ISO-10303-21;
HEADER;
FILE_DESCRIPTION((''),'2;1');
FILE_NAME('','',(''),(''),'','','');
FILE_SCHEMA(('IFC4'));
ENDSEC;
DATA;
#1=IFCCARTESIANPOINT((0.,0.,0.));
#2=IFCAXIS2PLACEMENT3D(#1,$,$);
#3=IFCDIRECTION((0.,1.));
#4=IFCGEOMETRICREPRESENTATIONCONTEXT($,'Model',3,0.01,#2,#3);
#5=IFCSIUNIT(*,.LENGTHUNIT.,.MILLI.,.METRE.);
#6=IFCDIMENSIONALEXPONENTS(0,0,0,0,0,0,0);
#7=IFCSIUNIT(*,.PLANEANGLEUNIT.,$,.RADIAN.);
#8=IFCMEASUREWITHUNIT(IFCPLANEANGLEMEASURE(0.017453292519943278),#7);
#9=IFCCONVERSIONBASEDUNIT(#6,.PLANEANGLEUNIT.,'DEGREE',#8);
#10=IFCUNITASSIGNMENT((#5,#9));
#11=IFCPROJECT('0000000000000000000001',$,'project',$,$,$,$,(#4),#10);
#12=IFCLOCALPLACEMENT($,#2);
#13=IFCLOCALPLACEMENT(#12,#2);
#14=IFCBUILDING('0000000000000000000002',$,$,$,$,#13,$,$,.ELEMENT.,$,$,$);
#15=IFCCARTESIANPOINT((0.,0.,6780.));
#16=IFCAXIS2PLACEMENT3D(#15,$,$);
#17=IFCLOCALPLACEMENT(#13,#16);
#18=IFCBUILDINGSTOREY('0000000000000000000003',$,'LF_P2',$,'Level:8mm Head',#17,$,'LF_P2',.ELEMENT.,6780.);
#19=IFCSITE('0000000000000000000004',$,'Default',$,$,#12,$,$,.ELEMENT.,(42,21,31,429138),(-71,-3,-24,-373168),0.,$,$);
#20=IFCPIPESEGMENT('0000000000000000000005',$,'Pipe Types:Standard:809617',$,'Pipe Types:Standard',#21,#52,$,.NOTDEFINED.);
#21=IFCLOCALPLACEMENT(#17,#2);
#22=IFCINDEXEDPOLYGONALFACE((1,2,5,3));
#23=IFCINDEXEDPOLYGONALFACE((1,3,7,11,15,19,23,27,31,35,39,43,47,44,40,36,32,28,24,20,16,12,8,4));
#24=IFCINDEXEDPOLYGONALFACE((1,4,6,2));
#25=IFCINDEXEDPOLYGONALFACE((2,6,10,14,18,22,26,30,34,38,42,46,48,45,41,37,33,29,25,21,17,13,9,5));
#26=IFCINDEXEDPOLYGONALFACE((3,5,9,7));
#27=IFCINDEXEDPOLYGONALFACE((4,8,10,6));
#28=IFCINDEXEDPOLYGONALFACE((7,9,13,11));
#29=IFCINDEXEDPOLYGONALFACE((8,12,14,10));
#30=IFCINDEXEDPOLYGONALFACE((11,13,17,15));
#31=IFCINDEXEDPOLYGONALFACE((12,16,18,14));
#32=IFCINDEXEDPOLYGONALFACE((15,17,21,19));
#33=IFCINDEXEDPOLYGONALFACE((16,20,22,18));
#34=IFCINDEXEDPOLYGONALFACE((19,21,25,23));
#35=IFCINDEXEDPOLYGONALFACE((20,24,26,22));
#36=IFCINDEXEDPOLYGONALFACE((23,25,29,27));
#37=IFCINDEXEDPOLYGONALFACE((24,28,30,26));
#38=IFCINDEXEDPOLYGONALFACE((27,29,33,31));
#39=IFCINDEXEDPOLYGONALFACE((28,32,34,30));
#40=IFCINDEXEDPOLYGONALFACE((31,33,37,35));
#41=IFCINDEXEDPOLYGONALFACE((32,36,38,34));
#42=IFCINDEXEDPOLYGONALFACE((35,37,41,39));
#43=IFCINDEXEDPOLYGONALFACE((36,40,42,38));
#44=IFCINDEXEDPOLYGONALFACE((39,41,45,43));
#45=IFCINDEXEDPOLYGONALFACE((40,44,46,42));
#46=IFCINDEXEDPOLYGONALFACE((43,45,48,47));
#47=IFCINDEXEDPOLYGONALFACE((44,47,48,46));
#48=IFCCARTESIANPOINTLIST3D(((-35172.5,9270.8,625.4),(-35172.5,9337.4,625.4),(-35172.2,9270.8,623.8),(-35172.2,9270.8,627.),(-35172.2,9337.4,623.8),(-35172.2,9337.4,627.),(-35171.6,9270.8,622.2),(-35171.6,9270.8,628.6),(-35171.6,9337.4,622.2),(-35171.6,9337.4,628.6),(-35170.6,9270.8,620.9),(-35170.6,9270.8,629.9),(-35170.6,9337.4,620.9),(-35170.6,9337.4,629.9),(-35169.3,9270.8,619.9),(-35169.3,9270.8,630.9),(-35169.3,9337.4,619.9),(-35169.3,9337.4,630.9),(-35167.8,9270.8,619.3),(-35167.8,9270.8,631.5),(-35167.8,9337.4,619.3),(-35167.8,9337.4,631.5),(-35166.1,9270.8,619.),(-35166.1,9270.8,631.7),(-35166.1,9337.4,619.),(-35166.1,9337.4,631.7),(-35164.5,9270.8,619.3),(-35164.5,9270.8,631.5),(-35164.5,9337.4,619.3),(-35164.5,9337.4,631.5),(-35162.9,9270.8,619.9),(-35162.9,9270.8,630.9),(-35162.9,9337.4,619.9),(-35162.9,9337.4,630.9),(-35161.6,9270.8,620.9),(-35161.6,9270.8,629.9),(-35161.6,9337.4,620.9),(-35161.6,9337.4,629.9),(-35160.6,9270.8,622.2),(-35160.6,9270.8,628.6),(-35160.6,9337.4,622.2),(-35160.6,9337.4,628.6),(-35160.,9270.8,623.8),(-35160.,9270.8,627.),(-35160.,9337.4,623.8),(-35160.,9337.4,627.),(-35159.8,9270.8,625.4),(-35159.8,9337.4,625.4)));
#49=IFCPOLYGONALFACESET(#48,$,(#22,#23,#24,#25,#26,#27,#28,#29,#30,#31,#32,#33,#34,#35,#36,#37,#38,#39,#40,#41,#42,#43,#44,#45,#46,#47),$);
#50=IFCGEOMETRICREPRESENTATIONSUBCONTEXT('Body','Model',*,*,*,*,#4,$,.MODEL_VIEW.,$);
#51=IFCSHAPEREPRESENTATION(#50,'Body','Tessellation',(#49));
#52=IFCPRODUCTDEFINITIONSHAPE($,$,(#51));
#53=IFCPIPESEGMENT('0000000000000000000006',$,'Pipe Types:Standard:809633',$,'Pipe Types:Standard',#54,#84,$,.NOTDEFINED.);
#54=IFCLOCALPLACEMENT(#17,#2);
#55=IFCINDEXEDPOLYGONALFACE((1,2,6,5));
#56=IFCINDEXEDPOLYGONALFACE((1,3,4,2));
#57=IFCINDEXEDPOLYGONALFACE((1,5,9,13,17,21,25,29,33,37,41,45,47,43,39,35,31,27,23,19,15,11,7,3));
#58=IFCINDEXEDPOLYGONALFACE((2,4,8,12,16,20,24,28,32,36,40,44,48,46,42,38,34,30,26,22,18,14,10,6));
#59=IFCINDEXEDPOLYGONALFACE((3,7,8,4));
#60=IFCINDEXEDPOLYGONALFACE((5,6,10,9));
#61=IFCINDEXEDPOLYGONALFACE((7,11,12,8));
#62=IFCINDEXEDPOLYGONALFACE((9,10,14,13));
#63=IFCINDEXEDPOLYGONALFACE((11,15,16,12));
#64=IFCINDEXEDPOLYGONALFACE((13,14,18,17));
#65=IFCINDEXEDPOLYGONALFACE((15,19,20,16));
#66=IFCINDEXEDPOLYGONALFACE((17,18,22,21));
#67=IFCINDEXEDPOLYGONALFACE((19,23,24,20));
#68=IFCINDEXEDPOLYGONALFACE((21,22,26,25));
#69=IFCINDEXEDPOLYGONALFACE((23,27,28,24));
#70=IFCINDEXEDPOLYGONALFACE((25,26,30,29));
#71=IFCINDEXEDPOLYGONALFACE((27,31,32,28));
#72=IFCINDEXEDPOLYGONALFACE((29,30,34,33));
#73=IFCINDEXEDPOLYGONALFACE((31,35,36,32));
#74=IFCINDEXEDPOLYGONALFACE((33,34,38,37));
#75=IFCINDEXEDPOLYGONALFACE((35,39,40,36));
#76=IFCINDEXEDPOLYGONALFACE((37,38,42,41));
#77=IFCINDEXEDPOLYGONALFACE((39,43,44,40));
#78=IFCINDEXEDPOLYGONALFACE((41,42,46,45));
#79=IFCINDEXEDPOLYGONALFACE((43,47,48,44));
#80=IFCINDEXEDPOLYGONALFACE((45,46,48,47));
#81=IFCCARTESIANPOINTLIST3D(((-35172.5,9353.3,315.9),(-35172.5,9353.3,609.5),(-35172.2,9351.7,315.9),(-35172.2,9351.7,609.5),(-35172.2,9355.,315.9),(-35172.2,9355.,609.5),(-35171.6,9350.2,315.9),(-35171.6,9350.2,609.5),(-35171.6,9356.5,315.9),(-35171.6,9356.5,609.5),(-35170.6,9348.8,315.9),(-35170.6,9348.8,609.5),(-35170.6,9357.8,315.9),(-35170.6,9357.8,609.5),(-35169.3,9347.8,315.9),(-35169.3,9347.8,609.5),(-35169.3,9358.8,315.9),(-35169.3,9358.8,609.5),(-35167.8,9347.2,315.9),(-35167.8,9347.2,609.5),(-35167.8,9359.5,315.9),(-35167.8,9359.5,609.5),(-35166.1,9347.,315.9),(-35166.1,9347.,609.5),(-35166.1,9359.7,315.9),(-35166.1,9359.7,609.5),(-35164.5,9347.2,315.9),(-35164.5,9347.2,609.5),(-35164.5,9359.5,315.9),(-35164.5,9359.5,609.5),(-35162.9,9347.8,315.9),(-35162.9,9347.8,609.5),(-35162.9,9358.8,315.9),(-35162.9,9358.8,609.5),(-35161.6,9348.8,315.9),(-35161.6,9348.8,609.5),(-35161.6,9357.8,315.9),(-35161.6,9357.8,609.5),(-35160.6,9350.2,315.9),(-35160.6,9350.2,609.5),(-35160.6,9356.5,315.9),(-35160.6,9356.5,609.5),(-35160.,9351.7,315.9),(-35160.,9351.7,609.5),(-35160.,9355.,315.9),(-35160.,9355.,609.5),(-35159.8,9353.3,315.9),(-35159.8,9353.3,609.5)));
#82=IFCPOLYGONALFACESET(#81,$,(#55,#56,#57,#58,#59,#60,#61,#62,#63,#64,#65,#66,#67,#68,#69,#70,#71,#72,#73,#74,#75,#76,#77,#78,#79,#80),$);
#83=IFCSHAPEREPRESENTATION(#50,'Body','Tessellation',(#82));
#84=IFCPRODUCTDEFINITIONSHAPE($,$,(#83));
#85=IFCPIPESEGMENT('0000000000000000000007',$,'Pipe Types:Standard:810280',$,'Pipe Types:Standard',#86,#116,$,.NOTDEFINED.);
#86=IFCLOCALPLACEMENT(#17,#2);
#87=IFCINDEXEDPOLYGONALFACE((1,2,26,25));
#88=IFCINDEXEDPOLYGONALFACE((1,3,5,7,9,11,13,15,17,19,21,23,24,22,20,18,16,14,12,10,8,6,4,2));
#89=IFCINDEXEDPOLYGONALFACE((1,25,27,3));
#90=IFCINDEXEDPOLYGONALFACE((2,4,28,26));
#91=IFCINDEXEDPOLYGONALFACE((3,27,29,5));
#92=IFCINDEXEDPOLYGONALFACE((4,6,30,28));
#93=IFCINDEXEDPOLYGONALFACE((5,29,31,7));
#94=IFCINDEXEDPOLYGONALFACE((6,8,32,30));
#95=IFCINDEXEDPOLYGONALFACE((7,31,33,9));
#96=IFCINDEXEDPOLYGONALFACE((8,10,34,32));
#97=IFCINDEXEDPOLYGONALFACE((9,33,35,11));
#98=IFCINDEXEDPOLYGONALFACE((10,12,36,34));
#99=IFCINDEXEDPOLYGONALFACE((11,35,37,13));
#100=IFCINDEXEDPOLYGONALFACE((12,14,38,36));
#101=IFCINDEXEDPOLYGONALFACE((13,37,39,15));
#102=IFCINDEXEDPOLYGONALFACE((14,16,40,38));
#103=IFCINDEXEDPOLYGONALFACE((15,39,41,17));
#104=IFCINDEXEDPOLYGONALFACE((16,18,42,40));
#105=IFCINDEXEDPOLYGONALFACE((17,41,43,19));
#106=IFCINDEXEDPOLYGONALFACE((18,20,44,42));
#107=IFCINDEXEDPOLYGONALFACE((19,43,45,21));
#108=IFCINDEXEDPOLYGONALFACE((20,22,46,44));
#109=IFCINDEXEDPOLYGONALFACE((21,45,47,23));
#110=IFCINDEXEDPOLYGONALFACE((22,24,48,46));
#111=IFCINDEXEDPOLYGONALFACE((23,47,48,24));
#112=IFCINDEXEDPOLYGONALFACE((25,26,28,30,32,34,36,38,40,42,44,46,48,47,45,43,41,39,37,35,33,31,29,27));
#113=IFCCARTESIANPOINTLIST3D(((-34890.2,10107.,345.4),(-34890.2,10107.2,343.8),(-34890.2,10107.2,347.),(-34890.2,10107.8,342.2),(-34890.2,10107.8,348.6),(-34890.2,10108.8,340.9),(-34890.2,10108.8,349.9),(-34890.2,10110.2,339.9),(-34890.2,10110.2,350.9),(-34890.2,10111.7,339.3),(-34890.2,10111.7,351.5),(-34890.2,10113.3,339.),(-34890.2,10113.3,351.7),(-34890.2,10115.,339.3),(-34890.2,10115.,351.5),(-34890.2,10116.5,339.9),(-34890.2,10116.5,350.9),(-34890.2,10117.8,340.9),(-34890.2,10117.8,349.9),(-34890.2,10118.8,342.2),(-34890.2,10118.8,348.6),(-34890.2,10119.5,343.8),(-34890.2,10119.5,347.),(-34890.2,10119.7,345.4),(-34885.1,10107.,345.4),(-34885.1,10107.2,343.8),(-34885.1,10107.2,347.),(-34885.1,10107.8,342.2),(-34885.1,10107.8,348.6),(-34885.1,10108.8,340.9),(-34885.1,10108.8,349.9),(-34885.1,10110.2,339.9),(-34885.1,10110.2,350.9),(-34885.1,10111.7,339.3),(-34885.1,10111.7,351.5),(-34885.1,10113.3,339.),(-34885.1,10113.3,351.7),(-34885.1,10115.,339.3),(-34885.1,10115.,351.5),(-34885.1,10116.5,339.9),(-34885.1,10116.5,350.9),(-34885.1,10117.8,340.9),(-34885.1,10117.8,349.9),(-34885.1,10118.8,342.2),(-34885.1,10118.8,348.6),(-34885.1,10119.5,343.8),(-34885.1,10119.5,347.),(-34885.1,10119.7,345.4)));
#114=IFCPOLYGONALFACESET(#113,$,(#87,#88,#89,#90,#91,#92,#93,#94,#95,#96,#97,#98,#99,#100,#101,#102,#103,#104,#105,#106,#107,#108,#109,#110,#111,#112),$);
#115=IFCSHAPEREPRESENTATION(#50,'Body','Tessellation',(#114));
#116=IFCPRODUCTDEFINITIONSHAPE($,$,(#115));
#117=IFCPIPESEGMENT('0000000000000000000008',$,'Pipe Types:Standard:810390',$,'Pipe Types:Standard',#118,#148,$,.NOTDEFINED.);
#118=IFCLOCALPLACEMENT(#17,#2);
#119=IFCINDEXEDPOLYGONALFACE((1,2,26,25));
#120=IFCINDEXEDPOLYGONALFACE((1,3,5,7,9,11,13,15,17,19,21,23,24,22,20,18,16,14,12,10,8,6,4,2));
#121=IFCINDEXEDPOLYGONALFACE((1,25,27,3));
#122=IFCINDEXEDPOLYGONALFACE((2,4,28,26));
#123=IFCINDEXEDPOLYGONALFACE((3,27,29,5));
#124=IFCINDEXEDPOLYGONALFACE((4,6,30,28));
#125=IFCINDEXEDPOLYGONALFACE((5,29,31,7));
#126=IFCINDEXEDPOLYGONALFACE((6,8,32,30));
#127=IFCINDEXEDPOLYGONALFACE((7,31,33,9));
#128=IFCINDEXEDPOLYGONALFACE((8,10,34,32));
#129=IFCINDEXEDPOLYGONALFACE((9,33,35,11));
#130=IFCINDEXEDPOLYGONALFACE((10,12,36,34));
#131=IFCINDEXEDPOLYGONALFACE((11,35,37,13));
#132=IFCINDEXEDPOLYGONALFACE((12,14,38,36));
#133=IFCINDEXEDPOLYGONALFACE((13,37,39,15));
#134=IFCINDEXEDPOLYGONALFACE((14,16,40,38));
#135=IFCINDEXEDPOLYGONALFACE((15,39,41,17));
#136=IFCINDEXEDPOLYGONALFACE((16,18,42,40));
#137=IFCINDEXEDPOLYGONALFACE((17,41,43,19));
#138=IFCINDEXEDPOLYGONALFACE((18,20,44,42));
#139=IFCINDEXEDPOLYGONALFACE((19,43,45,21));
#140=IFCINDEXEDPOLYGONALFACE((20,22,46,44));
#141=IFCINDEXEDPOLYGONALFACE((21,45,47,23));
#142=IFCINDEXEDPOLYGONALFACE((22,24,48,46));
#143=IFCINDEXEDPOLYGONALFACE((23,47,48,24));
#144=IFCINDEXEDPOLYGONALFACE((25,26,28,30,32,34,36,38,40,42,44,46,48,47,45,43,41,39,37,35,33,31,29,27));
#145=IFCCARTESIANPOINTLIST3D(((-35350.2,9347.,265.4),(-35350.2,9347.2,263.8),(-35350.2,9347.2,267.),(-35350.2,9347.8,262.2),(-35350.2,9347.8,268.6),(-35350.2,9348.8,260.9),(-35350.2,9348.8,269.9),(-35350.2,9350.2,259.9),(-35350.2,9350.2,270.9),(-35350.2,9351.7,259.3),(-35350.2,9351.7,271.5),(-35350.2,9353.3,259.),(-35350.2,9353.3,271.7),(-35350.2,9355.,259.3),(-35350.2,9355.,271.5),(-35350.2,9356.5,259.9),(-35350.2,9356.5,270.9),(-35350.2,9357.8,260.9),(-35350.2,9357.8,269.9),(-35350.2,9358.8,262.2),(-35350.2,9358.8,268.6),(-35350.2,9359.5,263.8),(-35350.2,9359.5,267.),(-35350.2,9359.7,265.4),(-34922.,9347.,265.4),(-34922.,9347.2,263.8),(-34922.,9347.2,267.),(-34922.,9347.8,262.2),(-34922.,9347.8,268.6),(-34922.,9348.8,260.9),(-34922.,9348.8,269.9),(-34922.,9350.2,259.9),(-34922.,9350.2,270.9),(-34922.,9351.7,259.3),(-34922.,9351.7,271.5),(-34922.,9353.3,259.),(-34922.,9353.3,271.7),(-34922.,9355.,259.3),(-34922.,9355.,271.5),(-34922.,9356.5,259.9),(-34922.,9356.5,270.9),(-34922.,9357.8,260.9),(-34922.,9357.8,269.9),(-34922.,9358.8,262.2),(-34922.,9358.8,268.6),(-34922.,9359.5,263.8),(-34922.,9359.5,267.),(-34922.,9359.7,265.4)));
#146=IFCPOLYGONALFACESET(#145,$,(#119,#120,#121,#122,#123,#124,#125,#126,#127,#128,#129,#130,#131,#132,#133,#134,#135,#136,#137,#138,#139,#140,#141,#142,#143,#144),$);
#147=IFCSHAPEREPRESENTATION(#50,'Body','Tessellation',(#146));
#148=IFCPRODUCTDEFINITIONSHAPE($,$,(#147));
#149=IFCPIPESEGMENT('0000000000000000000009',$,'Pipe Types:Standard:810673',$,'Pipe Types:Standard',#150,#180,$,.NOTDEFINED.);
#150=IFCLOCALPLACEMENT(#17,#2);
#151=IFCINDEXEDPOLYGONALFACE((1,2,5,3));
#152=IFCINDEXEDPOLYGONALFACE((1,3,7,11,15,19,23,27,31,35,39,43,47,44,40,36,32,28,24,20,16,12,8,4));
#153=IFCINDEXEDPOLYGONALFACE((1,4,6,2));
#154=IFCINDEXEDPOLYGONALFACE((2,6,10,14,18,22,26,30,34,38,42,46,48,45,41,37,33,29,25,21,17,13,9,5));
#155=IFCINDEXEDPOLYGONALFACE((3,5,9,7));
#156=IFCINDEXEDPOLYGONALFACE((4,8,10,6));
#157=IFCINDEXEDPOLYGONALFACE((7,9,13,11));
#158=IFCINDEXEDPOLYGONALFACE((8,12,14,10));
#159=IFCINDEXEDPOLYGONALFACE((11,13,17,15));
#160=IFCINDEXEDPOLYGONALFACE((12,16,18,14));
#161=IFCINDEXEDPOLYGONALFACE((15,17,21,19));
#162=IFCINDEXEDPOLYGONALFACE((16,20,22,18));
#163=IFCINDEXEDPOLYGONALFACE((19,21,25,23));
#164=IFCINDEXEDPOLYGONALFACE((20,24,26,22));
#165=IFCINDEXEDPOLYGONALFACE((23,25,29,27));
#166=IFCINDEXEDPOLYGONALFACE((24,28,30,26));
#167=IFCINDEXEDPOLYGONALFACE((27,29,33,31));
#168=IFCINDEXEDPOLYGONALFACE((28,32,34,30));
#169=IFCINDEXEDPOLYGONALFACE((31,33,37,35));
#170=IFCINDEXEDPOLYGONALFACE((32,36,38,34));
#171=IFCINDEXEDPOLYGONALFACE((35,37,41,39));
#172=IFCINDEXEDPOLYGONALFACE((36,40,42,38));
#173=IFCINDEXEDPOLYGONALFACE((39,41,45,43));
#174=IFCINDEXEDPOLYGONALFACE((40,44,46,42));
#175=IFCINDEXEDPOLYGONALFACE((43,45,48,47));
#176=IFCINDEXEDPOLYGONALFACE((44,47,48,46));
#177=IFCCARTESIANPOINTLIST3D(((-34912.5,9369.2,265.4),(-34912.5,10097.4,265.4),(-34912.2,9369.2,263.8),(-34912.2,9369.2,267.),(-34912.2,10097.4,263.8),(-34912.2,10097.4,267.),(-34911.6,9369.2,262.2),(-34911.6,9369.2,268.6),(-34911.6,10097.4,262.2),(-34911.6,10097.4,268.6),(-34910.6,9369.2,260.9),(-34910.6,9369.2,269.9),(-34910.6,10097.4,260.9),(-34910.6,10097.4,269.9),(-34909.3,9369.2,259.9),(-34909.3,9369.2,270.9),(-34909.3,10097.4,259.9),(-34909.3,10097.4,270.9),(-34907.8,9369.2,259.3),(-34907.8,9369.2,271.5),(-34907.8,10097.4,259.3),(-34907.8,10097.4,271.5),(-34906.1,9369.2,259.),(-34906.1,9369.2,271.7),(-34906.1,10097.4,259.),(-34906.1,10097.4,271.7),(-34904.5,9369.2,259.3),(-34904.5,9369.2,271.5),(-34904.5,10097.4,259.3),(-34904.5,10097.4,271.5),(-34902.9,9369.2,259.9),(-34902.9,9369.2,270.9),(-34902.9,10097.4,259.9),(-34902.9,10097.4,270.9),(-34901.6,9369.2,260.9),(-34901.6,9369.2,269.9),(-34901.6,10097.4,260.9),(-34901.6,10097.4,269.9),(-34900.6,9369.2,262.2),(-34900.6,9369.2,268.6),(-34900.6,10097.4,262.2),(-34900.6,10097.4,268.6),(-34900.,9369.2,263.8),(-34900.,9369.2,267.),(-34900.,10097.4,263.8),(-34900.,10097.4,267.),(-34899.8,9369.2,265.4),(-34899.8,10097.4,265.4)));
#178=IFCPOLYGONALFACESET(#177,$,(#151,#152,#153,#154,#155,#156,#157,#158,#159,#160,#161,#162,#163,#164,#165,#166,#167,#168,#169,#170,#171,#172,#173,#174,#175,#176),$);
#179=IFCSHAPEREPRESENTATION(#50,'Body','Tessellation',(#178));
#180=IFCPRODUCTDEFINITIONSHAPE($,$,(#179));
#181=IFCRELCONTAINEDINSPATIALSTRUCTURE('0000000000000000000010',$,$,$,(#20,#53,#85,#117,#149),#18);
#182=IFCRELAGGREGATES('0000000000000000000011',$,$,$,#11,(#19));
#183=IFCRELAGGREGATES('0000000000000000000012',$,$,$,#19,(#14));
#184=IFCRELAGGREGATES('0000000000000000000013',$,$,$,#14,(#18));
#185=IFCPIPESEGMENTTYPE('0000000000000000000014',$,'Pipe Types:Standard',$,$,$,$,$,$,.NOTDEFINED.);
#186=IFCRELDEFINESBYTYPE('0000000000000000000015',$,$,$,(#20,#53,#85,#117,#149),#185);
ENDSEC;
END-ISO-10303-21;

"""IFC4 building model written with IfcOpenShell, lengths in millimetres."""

from ifc_helpers import new_model, entity, si_unit, converted_unit, direction, frame, origin, place, context, subcontext, project, spatial, arc, indexed_curve, outline, extrude, type_object, element, save


model = new_model("IFC4")

# Units and contexts
model_context = context("Model", 3, precision=0.01, world=origin(), true_north=direction((0.0, 1.0)))
body_context = subcontext(model_context, "Body", "Model", "MODEL_VIEW")
ifc_project = project(units=[si_unit("LENGTHUNIT", "METRE", prefix="MILLI"), converted_unit("PLANEANGLEUNIT", "DEGREE", entity("IfcPlaneAngleMeasure", 0.017453292519943278), si_unit("PLANEANGLEUNIT", "RADIAN"), dimensions=[0, 0, 0, 0, 0, 0, 0])], contexts=[model_context])

# Site, building, storey
site_placement = place(None, origin())
site = spatial("IfcSite", under=ifc_project, at=site_placement, Name="Default", CompositionType="ELEMENT", RefLatitude=(42, 21, 31, 429138), RefLongitude=(-71, -3, -24, -373168), RefElevation=0.0)
building_placement = place(site_placement, origin())
building = spatial("IfcBuilding", under=site, at=building_placement, CompositionType="ELEMENT")
storey_placement = place(building_placement, frame((0.0, 0.0, 6780.0)))
storey = spatial("IfcBuildingStorey", under=building, at=storey_placement, Name="LF_P2", ObjectType="Level:8mm Head", LongName="LF_P2", CompositionType="ELEMENT", Elevation=6780.0)

# Pipe segments
pipe_segment_type_1 = type_object("IfcPipeSegmentType", Name="Pipe Types:Standard", PredefinedType="NOTDEFINED")
pipe_segment_1_placement = place(storey_placement, origin())
element("IfcPipeSegment", 1, at=pipe_segment_1_placement, inside=storey, type_object=pipe_segment_type_1, Name="Pipe Types:Standard:809617", ObjectType="Pipe Types:Standard", PredefinedType="NOTDEFINED", context=body_context, shape_type="SweptSolid", body=[
    extrude(outline(indexed_curve([(6.3, 0.0), (4.5, 4.5), (0.0, 6.3), (-4.5, 4.5), (-6.4, 0.0), (-4.5, -4.5), (0.0, -6.3), (4.5, -4.5)], segments=[arc(1, 2, 3), arc(3, 4, 5), arc(5, 6, 7), arc(7, 8, 1)], self_intersect=False)), frame((-35166.1, 9270.8, 625.4), z_axis=(0.0, 1.0, 0.0), x_axis=(1.0, 0.0, 0.0)), (0.0, 0.0, 1.0), 66.6),
])
pipe_segment_2_placement = place(storey_placement, origin())
element("IfcPipeSegment", 2, at=pipe_segment_2_placement, inside=storey, type_object=pipe_segment_type_1, Name="Pipe Types:Standard:809633", ObjectType="Pipe Types:Standard", PredefinedType="NOTDEFINED", context=body_context, shape_type="SweptSolid", body=[
    extrude(outline(indexed_curve([(6.3, 0.0), (4.5, 4.5), (0.0, 6.3), (-4.5, 4.5), (-6.4, 0.0), (-4.5, -4.5), (0.0, -6.3), (4.5, -4.5)], segments=[arc(1, 2, 3), arc(3, 4, 5), arc(5, 6, 7), arc(7, 8, 1)], self_intersect=False)), frame((-35166.1, 9353.3, 315.9)), (0.0, 0.0, 1.0), 293.6),
])
pipe_segment_3_placement = place(storey_placement, origin())
element("IfcPipeSegment", 3, at=pipe_segment_3_placement, inside=storey, type_object=pipe_segment_type_1, Name="Pipe Types:Standard:810280", ObjectType="Pipe Types:Standard", PredefinedType="NOTDEFINED", context=body_context, shape_type="SweptSolid", body=[
    extrude(outline(indexed_curve([(6.3, 0.0), (4.5, 4.5), (0.0, 6.3), (-4.5, 4.5), (-6.4, 0.0), (-4.5, -4.5), (0.0, -6.3), (4.5, -4.5)], segments=[arc(1, 2, 3), arc(3, 4, 5), arc(5, 6, 7), arc(7, 8, 1)], self_intersect=False)), frame((-34890.2, 10113.3, 345.4), z_axis=(1.0, 0.0, 0.0), x_axis=(0.0, 1.0, 0.0)), (0.0, 0.0, 1.0), 5.1),
])
pipe_segment_4_placement = place(storey_placement, origin())
element("IfcPipeSegment", 4, at=pipe_segment_4_placement, inside=storey, type_object=pipe_segment_type_1, Name="Pipe Types:Standard:810390", ObjectType="Pipe Types:Standard", PredefinedType="NOTDEFINED", context=body_context, shape_type="SweptSolid", body=[
    extrude(outline(indexed_curve([(6.3, 0.0), (4.5, 4.5), (0.0, 6.3), (-4.5, 4.5), (-6.3, 0.0), (-4.5, -4.5), (0.0, -6.3), (4.5, -4.5)], segments=[arc(1, 2, 3), arc(3, 4, 5), arc(5, 6, 7), arc(7, 8, 1)], self_intersect=False)), frame((-35350.2, 9353.3, 265.4), z_axis=(1.0, 0.0, 0.0), x_axis=(0.0, -1.0, 0.0)), (0.0, 0.0, 1.0), 428.2),
])
pipe_segment_5_placement = place(storey_placement, origin())
element("IfcPipeSegment", 5, at=pipe_segment_5_placement, inside=storey, type_object=pipe_segment_type_1, Name="Pipe Types:Standard:810673", ObjectType="Pipe Types:Standard", PredefinedType="NOTDEFINED", context=body_context, shape_type="SweptSolid", body=[
    extrude(outline(indexed_curve([(6.3, 0.0), (4.5, 4.5), (0.0, 6.3), (-4.5, 4.5), (-6.3, 0.0), (-4.5, -4.5), (0.0, -6.3), (4.5, -4.5)], segments=[arc(1, 2, 3), arc(3, 4, 5), arc(5, 6, 7), arc(7, 8, 1)], self_intersect=False)), frame((-34906.1, 9369.2, 265.4), z_axis=(0.0, 1.0, 0.0), x_axis=(1.0, 0.0, 0.0)), (0.0, 0.0, 1.0), 728.2),
])

save(model, "model.ifc")
